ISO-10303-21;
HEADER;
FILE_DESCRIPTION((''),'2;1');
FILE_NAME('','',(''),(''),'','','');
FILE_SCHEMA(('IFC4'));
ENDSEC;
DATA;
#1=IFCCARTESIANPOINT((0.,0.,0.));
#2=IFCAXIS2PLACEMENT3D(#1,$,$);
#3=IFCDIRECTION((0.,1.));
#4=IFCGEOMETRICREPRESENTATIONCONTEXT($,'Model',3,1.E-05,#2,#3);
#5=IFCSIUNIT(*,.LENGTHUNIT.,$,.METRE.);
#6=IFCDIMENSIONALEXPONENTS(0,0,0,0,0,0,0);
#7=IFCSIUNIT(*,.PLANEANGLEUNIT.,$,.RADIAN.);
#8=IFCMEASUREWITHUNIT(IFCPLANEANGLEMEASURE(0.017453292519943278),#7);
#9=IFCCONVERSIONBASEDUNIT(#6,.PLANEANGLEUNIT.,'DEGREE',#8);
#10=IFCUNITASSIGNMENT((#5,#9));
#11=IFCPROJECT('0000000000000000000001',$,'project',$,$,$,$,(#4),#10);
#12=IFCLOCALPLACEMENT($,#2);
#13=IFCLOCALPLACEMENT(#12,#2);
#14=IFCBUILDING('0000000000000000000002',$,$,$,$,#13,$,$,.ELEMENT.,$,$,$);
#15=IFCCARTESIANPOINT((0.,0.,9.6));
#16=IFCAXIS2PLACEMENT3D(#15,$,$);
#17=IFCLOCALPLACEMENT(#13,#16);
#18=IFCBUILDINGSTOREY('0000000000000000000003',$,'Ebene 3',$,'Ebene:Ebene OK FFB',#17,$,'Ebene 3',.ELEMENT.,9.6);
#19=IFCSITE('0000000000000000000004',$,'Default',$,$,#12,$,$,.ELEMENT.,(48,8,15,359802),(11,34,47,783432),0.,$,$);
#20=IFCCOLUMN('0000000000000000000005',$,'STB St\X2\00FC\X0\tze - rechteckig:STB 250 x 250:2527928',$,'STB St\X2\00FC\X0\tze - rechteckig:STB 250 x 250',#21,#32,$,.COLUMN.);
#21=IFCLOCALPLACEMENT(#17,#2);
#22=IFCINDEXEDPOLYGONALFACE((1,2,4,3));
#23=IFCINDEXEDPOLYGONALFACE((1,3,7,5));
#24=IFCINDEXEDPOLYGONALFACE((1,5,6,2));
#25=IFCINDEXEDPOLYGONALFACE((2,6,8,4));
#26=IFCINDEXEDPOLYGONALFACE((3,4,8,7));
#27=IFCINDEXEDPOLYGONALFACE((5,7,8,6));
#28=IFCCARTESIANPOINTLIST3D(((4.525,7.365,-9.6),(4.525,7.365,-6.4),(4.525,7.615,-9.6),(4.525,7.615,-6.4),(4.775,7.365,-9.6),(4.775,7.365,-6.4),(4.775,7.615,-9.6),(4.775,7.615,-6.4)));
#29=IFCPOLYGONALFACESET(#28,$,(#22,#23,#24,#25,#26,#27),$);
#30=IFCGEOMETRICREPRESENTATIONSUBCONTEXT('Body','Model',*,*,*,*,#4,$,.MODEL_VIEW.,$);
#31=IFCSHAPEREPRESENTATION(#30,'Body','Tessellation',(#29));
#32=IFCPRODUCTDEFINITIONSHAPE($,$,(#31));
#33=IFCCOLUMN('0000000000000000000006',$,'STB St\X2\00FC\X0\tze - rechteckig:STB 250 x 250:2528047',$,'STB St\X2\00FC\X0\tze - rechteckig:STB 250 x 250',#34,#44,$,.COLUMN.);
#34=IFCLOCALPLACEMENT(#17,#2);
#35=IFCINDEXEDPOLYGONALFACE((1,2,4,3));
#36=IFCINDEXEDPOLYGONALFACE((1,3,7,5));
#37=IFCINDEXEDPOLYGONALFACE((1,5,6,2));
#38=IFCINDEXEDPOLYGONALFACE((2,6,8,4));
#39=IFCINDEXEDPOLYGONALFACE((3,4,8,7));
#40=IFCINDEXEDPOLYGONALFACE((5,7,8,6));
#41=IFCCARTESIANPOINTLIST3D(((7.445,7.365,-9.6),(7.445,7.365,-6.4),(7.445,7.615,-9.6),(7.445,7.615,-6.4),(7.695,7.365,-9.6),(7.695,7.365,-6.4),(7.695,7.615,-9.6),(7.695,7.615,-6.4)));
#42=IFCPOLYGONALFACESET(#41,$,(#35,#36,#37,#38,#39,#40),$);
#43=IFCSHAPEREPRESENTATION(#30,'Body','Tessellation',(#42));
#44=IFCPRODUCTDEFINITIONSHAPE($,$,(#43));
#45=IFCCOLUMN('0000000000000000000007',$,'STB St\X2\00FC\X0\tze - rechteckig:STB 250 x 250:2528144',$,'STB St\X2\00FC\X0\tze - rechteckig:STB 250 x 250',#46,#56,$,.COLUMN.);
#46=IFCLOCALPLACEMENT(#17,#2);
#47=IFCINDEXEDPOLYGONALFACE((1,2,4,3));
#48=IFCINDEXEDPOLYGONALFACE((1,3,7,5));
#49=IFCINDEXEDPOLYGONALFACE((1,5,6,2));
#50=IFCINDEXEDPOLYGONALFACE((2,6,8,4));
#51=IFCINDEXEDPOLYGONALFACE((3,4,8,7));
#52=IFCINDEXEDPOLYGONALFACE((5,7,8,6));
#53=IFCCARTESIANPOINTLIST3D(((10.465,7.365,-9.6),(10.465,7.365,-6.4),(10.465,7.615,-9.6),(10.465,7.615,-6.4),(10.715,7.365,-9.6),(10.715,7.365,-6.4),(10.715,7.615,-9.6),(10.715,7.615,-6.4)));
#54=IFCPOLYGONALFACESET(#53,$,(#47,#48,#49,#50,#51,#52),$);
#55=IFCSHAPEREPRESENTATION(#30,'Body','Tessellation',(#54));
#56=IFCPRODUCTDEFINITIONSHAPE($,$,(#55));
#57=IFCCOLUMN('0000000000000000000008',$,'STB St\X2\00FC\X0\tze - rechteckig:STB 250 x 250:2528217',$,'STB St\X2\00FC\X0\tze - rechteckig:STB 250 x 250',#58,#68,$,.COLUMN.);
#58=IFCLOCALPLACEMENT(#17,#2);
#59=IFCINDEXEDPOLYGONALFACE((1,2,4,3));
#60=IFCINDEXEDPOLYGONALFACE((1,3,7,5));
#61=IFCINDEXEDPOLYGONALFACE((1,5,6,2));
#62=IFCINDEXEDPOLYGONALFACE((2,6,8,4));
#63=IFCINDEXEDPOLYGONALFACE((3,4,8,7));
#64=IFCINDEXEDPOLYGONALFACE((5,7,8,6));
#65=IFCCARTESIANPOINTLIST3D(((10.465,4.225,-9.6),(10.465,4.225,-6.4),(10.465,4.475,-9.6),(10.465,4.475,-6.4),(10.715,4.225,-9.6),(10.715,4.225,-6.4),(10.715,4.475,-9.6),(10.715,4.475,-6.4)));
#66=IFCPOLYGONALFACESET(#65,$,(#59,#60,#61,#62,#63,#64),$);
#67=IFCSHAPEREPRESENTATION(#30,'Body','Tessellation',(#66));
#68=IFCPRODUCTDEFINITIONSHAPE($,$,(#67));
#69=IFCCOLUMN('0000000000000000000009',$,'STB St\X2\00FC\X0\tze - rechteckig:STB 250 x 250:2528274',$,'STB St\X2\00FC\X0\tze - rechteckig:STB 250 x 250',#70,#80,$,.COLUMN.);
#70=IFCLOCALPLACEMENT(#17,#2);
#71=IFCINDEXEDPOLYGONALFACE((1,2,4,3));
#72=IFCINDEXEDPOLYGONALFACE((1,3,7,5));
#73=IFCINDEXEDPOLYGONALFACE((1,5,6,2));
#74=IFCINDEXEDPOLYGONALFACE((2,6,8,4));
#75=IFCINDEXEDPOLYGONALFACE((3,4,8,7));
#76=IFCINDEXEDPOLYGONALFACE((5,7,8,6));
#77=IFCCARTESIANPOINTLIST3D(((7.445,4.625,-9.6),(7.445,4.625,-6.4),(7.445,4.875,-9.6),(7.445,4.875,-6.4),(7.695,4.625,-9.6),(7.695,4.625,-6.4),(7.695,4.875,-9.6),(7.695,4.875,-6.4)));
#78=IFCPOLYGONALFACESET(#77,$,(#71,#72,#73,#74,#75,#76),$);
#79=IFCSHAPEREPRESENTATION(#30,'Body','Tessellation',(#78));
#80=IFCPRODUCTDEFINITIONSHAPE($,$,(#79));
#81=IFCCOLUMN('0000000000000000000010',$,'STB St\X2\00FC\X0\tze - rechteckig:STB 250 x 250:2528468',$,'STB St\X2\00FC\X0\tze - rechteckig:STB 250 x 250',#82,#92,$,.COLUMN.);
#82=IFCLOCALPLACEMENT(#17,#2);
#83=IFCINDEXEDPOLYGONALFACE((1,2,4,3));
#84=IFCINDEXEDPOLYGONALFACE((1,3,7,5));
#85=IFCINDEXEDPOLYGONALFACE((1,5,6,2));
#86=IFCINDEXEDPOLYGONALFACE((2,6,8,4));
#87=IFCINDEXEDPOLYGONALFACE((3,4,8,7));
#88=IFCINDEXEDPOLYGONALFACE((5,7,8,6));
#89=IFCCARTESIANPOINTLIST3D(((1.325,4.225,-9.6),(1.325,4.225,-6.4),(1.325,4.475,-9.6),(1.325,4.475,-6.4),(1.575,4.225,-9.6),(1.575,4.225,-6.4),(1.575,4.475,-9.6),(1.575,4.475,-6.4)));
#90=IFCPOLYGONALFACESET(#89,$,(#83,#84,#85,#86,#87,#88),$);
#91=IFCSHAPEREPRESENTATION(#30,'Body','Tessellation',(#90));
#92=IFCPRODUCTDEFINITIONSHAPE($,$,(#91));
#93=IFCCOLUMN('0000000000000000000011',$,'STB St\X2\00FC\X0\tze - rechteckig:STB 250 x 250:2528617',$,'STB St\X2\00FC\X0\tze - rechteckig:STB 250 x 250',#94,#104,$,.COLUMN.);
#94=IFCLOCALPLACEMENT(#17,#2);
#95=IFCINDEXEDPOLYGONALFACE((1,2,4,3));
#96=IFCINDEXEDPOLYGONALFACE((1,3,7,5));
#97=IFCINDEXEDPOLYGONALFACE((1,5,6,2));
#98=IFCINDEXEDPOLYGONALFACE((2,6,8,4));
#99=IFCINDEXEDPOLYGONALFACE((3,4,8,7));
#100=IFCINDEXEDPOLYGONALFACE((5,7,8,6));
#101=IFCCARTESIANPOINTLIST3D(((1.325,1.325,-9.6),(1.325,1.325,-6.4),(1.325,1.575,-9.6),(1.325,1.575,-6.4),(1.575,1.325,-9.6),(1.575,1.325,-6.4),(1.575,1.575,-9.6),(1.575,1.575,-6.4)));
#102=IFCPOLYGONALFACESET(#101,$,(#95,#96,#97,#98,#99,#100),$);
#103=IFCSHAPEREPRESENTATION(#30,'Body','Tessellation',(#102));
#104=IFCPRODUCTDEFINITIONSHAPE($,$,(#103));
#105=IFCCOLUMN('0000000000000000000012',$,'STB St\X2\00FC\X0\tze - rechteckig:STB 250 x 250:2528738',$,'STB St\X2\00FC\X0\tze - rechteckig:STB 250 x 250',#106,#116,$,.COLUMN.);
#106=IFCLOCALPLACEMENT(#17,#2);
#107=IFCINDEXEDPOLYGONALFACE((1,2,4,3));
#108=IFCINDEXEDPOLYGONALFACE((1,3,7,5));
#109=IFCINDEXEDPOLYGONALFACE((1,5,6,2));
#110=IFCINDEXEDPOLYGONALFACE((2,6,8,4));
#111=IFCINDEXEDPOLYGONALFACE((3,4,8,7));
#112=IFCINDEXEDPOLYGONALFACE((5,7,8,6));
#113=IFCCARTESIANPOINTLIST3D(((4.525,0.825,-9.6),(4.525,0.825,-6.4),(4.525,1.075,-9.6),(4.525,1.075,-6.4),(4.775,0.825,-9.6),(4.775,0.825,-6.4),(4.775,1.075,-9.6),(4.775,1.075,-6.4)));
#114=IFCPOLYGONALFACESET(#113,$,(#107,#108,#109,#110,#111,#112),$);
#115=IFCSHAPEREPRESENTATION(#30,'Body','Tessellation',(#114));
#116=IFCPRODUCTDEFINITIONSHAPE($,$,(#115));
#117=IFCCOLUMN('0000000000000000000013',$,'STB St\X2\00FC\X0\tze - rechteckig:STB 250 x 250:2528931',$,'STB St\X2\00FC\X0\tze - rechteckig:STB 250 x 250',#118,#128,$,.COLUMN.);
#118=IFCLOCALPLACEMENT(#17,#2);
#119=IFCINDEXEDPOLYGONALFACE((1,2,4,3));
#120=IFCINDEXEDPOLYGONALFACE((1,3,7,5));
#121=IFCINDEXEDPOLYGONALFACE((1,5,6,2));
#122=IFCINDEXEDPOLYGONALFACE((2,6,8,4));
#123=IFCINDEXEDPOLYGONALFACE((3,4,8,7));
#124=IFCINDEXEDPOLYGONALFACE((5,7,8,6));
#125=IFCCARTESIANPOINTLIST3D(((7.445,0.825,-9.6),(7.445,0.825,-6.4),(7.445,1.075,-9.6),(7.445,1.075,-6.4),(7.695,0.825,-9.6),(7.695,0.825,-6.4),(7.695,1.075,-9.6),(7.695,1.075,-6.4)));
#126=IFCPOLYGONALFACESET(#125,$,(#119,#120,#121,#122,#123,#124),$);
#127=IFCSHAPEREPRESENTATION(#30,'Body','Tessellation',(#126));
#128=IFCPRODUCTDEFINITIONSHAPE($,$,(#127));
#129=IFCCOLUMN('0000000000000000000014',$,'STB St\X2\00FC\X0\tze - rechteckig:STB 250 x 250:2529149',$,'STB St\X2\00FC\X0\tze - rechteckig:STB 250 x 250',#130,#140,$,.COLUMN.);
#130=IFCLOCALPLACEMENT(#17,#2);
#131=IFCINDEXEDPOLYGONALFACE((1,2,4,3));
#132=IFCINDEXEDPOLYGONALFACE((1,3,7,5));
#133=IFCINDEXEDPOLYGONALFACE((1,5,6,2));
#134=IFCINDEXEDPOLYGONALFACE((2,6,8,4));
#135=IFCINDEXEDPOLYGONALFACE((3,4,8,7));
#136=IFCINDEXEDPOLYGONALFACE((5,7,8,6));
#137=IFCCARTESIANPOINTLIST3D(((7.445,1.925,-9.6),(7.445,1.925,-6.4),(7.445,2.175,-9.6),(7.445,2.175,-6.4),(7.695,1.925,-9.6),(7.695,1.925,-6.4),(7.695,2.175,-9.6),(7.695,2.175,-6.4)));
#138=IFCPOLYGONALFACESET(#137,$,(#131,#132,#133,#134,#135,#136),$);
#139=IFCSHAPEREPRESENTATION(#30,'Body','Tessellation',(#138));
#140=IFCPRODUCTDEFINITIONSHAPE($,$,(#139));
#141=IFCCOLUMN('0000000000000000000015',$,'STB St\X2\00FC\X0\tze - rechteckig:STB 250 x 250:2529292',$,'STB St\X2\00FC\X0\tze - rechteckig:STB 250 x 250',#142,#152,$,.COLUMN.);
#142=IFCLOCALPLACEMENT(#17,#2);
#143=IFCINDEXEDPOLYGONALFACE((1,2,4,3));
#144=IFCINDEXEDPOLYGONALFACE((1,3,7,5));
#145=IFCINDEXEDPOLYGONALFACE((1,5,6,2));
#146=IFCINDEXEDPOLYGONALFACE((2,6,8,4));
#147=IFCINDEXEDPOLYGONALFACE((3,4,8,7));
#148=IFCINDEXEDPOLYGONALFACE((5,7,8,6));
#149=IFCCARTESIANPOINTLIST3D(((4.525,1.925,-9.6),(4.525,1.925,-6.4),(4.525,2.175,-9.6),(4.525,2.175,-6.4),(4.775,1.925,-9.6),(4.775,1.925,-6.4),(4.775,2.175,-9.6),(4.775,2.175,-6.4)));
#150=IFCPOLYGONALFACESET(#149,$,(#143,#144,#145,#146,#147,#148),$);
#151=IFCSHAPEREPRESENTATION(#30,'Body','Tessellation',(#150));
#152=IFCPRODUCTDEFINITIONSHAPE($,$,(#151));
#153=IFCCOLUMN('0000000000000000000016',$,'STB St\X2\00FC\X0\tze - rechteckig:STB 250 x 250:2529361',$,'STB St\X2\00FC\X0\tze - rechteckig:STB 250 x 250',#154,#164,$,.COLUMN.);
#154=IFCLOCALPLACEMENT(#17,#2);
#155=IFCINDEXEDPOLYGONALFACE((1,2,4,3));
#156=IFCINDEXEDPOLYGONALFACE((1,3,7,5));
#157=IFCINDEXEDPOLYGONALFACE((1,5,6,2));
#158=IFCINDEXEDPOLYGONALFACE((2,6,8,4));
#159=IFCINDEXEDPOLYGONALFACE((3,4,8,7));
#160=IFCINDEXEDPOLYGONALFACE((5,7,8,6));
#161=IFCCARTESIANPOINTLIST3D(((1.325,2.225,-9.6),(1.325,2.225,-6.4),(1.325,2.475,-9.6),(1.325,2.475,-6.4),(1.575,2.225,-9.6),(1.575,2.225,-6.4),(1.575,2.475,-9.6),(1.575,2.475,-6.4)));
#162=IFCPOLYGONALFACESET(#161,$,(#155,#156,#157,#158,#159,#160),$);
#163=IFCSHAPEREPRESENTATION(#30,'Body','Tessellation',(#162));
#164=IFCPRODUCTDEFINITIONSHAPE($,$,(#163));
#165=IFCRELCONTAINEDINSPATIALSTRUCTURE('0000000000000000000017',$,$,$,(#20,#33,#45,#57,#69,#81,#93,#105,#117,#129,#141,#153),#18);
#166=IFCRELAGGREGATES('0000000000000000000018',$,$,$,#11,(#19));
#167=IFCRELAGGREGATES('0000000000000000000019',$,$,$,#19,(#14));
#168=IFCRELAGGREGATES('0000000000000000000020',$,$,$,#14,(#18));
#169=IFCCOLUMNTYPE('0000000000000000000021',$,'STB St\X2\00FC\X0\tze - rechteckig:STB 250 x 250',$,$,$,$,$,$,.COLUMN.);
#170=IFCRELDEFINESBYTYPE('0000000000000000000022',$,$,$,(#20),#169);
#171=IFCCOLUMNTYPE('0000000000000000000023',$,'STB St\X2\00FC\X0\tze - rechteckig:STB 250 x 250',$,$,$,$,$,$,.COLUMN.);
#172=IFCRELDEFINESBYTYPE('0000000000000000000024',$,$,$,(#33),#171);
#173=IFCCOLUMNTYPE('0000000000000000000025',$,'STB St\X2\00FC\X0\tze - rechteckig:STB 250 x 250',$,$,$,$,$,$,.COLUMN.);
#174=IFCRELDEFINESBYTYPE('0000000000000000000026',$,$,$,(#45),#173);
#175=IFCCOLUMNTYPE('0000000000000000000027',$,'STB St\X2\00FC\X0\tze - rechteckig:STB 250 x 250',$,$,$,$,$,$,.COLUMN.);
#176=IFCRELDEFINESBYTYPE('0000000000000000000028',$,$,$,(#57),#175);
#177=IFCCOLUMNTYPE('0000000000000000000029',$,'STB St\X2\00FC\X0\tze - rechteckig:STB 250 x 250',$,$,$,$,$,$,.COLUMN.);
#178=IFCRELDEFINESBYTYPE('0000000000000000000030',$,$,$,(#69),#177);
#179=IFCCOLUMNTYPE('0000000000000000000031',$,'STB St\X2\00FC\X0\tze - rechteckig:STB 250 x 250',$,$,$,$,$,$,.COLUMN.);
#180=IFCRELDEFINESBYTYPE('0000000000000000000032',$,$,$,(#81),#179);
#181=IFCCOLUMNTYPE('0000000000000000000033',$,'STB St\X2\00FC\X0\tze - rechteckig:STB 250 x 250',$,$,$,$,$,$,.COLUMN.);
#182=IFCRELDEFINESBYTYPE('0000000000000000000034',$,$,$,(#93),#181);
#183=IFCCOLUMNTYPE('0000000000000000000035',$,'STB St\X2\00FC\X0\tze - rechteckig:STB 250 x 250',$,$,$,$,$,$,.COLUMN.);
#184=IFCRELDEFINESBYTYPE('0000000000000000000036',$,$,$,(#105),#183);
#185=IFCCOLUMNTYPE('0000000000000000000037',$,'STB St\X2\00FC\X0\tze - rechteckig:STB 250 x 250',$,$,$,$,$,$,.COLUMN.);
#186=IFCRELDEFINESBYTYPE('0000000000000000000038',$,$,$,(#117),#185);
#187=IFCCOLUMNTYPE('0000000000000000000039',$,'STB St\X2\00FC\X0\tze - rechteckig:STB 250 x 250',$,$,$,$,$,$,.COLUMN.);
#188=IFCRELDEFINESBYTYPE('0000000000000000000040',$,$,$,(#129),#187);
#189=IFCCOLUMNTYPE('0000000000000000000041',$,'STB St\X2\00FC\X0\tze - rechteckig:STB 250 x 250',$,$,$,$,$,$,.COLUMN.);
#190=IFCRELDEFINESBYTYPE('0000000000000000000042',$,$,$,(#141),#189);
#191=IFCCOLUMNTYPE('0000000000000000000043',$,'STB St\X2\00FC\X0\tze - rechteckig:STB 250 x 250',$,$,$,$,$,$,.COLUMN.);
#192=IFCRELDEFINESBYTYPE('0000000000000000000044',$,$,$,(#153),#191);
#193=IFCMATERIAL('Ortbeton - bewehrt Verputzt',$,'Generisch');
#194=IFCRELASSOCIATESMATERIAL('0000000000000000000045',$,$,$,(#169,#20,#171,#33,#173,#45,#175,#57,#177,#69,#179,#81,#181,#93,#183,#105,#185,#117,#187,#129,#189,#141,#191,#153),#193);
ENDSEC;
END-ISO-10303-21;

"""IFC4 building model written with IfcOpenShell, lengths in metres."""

from ifc_helpers import new_model, entity, si_unit, converted_unit, direction, frame, origin, place, context, subcontext, project, spatial, indexed_curve, outline, extrude, source, transform, mapped, material, type_object, type_shapes, element, save


model = new_model("IFC4")

# Units and contexts
model_context = context("Model", 3, precision=1e-05, world=origin(), true_north=direction((0.0, 1.0)))
body_context = subcontext(model_context, "Body", "Model", "MODEL_VIEW")
ifc_project = project(units=[si_unit("LENGTHUNIT", "METRE"), converted_unit("PLANEANGLEUNIT", "DEGREE", entity("IfcPlaneAngleMeasure", 0.017453292519943278), si_unit("PLANEANGLEUNIT", "RADIAN"), dimensions=[0, 0, 0, 0, 0, 0, 0])], contexts=[model_context])

# Site, building, storey
site_placement = place(None, origin())
site = spatial("IfcSite", under=ifc_project, at=site_placement, Name="Default", CompositionType="ELEMENT", RefLatitude=(48, 8, 15, 359802), RefLongitude=(11, 34, 47, 783432), RefElevation=0.0)
building_placement = place(site_placement, origin())
building = spatial("IfcBuilding", under=site, at=building_placement, CompositionType="ELEMENT")
storey_placement = place(building_placement, frame((0.0, 0.0, 9.6)))
storey = spatial("IfcBuildingStorey", under=building, at=storey_placement, Name="Ebene 3", ObjectType="Ebene:Ebene OK FFB", LongName="Ebene 3", CompositionType="ELEMENT", Elevation=9.6)

# Columns
ifc_material_1 = material(Name="Ortbeton - bewehrt Verputzt", Category="Generisch")
column_type_1 = type_object("IfcColumnType", Name="STB Stütze - rechteckig:STB 250 x 250", PredefinedType="COLUMN", material=ifc_material_1)
shared_shape_1 = source(origin(), body_context, "Body", "SweptSolid", [
    extrude(outline(indexed_curve([(-0.125, -0.125), (0.125, -0.125), (0.125, 0.125), (-0.125, 0.125), (-0.125, -0.125)], self_intersect=False)), frame((4.65, 7.49, 0.0), z_axis=(0.0, 0.0, 1.0), x_axis=(-1.0, 0.0, 0.0)), (0.0, 0.0, 1.0), 3.2),
])
type_shapes(column_type_1, [shared_shape_1])
column_1_placement = place(storey_placement, frame((0.0, 0.0, -9.6)))
element("IfcColumn", 1, at=column_1_placement, inside=storey, type_object=column_type_1, material=ifc_material_1, Name="STB Stütze - rechteckig:STB 250 x 250:2527928", ObjectType="STB Stütze - rechteckig:STB 250 x 250", PredefinedType="COLUMN", context=body_context, shape_type="MappedRepresentation", body=[
    mapped(shared_shape_1, transform((0.0, 0.0, 0.0), scale=1.0)),
])
column_type_2 = type_object("IfcColumnType", Name="STB Stütze - rechteckig:STB 250 x 250", PredefinedType="COLUMN", material=ifc_material_1)
shared_shape_2 = source(origin(), body_context, "Body", "SweptSolid", [
    extrude(outline(indexed_curve([(-0.125, -0.125), (0.125, -0.125), (0.125, 0.125), (-0.125, 0.125), (-0.125, -0.125)], self_intersect=False)), frame((7.57, 7.49, 0.0), z_axis=(0.0, 0.0, 1.0), x_axis=(-1.0, 0.0, 0.0)), (0.0, 0.0, 1.0), 3.2),
])
type_shapes(column_type_2, [shared_shape_2])
column_2_placement = place(storey_placement, frame((0.0, 0.0, -9.6)))
element("IfcColumn", 2, at=column_2_placement, inside=storey, type_object=column_type_2, material=ifc_material_1, Name="STB Stütze - rechteckig:STB 250 x 250:2528047", ObjectType="STB Stütze - rechteckig:STB 250 x 250", PredefinedType="COLUMN", context=body_context, shape_type="MappedRepresentation", body=[
    mapped(shared_shape_2, transform((0.0, 0.0, 0.0), scale=1.0)),
])
column_type_3 = type_object("IfcColumnType", Name="STB Stütze - rechteckig:STB 250 x 250", PredefinedType="COLUMN", material=ifc_material_1)
shared_shape_3 = source(origin(), body_context, "Body", "SweptSolid", [
    extrude(outline(indexed_curve([(-0.125, -0.125), (0.125, -0.125), (0.125, 0.125), (-0.125, 0.125), (-0.125, -0.125)], self_intersect=False)), frame((10.59, 7.49, 0.0), z_axis=(0.0, 0.0, 1.0), x_axis=(-1.0, 0.0, 0.0)), (0.0, 0.0, 1.0), 3.2),
])
type_shapes(column_type_3, [shared_shape_3])
column_3_placement = place(storey_placement, frame((0.0, 0.0, -9.6)))
element("IfcColumn", 3, at=column_3_placement, inside=storey, type_object=column_type_3, material=ifc_material_1, Name="STB Stütze - rechteckig:STB 250 x 250:2528144", ObjectType="STB Stütze - rechteckig:STB 250 x 250", PredefinedType="COLUMN", context=body_context, shape_type="MappedRepresentation", body=[
    mapped(shared_shape_3, transform((0.0, 0.0, 0.0), scale=1.0)),
])
column_type_4 = type_object("IfcColumnType", Name="STB Stütze - rechteckig:STB 250 x 250", PredefinedType="COLUMN", material=ifc_material_1)
shared_shape_4 = source(origin(), body_context, "Body", "SweptSolid", [
    extrude(outline(indexed_curve([(-0.125, -0.125), (0.125, -0.125), (0.125, 0.125), (-0.125, 0.125), (-0.125, -0.125)], self_intersect=False)), frame((10.59, 4.35, 0.0), z_axis=(0.0, 0.0, 1.0), x_axis=(-1.0, 0.0, 0.0)), (0.0, 0.0, 1.0), 3.2),
])
type_shapes(column_type_4, [shared_shape_4])
column_4_placement = place(storey_placement, frame((0.0, 0.0, -9.6)))
element("IfcColumn", 4, at=column_4_placement, inside=storey, type_object=column_type_4, material=ifc_material_1, Name="STB Stütze - rechteckig:STB 250 x 250:2528217", ObjectType="STB Stütze - rechteckig:STB 250 x 250", PredefinedType="COLUMN", context=body_context, shape_type="MappedRepresentation", body=[
    mapped(shared_shape_4, transform((0.0, 0.0, 0.0), scale=1.0)),
])
column_type_5 = type_object("IfcColumnType", Name="STB Stütze - rechteckig:STB 250 x 250", PredefinedType="COLUMN", material=ifc_material_1)
shared_shape_5 = source(origin(), body_context, "Body", "SweptSolid", [
    extrude(outline(indexed_curve([(-0.125, -0.125), (0.125, -0.125), (0.125, 0.125), (-0.125, 0.125), (-0.125, -0.125)], self_intersect=False)), frame((7.57, 4.75, 0.0), z_axis=(0.0, 0.0, 1.0), x_axis=(-1.0, 0.0, 0.0)), (0.0, 0.0, 1.0), 3.2),
])
type_shapes(column_type_5, [shared_shape_5])
column_5_placement = place(storey_placement, frame((0.0, 0.0, -9.6)))
element("IfcColumn", 5, at=column_5_placement, inside=storey, type_object=column_type_5, material=ifc_material_1, Name="STB Stütze - rechteckig:STB 250 x 250:2528274", ObjectType="STB Stütze - rechteckig:STB 250 x 250", PredefinedType="COLUMN", context=body_context, shape_type="MappedRepresentation", body=[
    mapped(shared_shape_5, transform((0.0, 0.0, 0.0), scale=1.0)),
])
column_type_6 = type_object("IfcColumnType", Name="STB Stütze - rechteckig:STB 250 x 250", PredefinedType="COLUMN", material=ifc_material_1)
shared_shape_6 = source(origin(), body_context, "Body", "SweptSolid", [
    extrude(outline(indexed_curve([(-0.125, -0.125), (0.125, -0.125), (0.125, 0.125), (-0.125, 0.125), (-0.125, -0.125)], self_intersect=False)), frame((1.45, 4.35, 0.0), z_axis=(0.0, 0.0, 1.0), x_axis=(-1.0, 0.0, 0.0)), (0.0, 0.0, 1.0), 3.2),
])
type_shapes(column_type_6, [shared_shape_6])
column_6_placement = place(storey_placement, frame((0.0, 0.0, -9.6)))
element("IfcColumn", 6, at=column_6_placement, inside=storey, type_object=column_type_6, material=ifc_material_1, Name="STB Stütze - rechteckig:STB 250 x 250:2528468", ObjectType="STB Stütze - rechteckig:STB 250 x 250", PredefinedType="COLUMN", context=body_context, shape_type="MappedRepresentation", body=[
    mapped(shared_shape_6, transform((0.0, 0.0, 0.0), scale=1.0)),
])
column_type_7 = type_object("IfcColumnType", Name="STB Stütze - rechteckig:STB 250 x 250", PredefinedType="COLUMN", material=ifc_material_1)
shared_shape_7 = source(origin(), body_context, "Body", "SweptSolid", [
    extrude(outline(indexed_curve([(-0.125, -0.125), (0.125, -0.125), (0.125, 0.125), (-0.125, 0.125), (-0.125, -0.125)], self_intersect=False)), frame((1.45, 1.45, 0.0), z_axis=(0.0, 0.0, 1.0), x_axis=(-1.0, 0.0, 0.0)), (0.0, 0.0, 1.0), 3.2),
])
type_shapes(column_type_7, [shared_shape_7])
column_7_placement = place(storey_placement, frame((0.0, 0.0, -9.6)))
element("IfcColumn", 7, at=column_7_placement, inside=storey, type_object=column_type_7, material=ifc_material_1, Name="STB Stütze - rechteckig:STB 250 x 250:2528617", ObjectType="STB Stütze - rechteckig:STB 250 x 250", PredefinedType="COLUMN", context=body_context, shape_type="MappedRepresentation", body=[
    mapped(shared_shape_7, transform((0.0, 0.0, 0.0), scale=1.0)),
])
column_type_8 = type_object("IfcColumnType", Name="STB Stütze - rechteckig:STB 250 x 250", PredefinedType="COLUMN", material=ifc_material_1)
shared_shape_8 = source(origin(), body_context, "Body", "SweptSolid", [
    extrude(outline(indexed_curve([(-0.125, -0.125), (0.125, -0.125), (0.125, 0.125), (-0.125, 0.125), (-0.125, -0.125)], self_intersect=False)), frame((4.65, 0.95, 0.0), z_axis=(0.0, 0.0, 1.0), x_axis=(-1.0, 0.0, 0.0)), (0.0, 0.0, 1.0), 3.2),
])
type_shapes(column_type_8, [shared_shape_8])
column_8_placement = place(storey_placement, frame((0.0, 0.0, -9.6)))
element("IfcColumn", 8, at=column_8_placement, inside=storey, type_object=column_type_8, material=ifc_material_1, Name="STB Stütze - rechteckig:STB 250 x 250:2528738", ObjectType="STB Stütze - rechteckig:STB 250 x 250", PredefinedType="COLUMN", context=body_context, shape_type="MappedRepresentation", body=[
    mapped(shared_shape_8, transform((0.0, 0.0, 0.0), scale=1.0)),
])
column_type_9 = type_object("IfcColumnType", Name="STB Stütze - rechteckig:STB 250 x 250", PredefinedType="COLUMN", material=ifc_material_1)
shared_shape_9 = source(origin(), body_context, "Body", "SweptSolid", [
    extrude(outline(indexed_curve([(-0.125, -0.125), (0.125, -0.125), (0.125, 0.125), (-0.125, 0.125), (-0.125, -0.125)], self_intersect=False)), frame((7.57, 0.95, 0.0), z_axis=(0.0, 0.0, 1.0), x_axis=(-1.0, 0.0, 0.0)), (0.0, 0.0, 1.0), 3.2),
])
type_shapes(column_type_9, [shared_shape_9])
column_9_placement = place(storey_placement, frame((0.0, 0.0, -9.6)))
element("IfcColumn", 9, at=column_9_placement, inside=storey, type_object=column_type_9, material=ifc_material_1, Name="STB Stütze - rechteckig:STB 250 x 250:2528931", ObjectType="STB Stütze - rechteckig:STB 250 x 250", PredefinedType="COLUMN", context=body_context, shape_type="MappedRepresentation", body=[
    mapped(shared_shape_9, transform((0.0, 0.0, 0.0), scale=1.0)),
])
column_type_10 = type_object("IfcColumnType", Name="STB Stütze - rechteckig:STB 250 x 250", PredefinedType="COLUMN", material=ifc_material_1)
shared_shape_10 = source(origin(), body_context, "Body", "SweptSolid", [
    extrude(outline(indexed_curve([(-0.125, -0.125), (0.125, -0.125), (0.125, 0.125), (-0.125, 0.125), (-0.125, -0.125)], self_intersect=False)), frame((7.57, 2.05, 0.0), z_axis=(0.0, 0.0, 1.0), x_axis=(-1.0, 0.0, 0.0)), (0.0, 0.0, 1.0), 3.2),
])
type_shapes(column_type_10, [shared_shape_10])
column_10_placement = place(storey_placement, frame((0.0, 0.0, -9.6)))
element("IfcColumn", 10, at=column_10_placement, inside=storey, type_object=column_type_10, material=ifc_material_1, Name="STB Stütze - rechteckig:STB 250 x 250:2529149", ObjectType="STB Stütze - rechteckig:STB 250 x 250", PredefinedType="COLUMN", context=body_context, shape_type="MappedRepresentation", body=[
    mapped(shared_shape_10, transform((0.0, 0.0, 0.0), scale=1.0)),
])
column_type_11 = type_object("IfcColumnType", Name="STB Stütze - rechteckig:STB 250 x 250", PredefinedType="COLUMN", material=ifc_material_1)
shared_shape_11 = source(origin(), body_context, "Body", "SweptSolid", [
    extrude(outline(indexed_curve([(-0.125, -0.125), (0.125, -0.125), (0.125, 0.125), (-0.125, 0.125), (-0.125, -0.125)], self_intersect=False)), frame((4.65, 2.05, 0.0), z_axis=(0.0, 0.0, 1.0), x_axis=(-1.0, 0.0, 0.0)), (0.0, 0.0, 1.0), 3.2),
])
type_shapes(column_type_11, [shared_shape_11])
column_11_placement = place(storey_placement, frame((0.0, 0.0, -9.6)))
element("IfcColumn", 11, at=column_11_placement, inside=storey, type_object=column_type_11, material=ifc_material_1, Name="STB Stütze - rechteckig:STB 250 x 250:2529292", ObjectType="STB Stütze - rechteckig:STB 250 x 250", PredefinedType="COLUMN", context=body_context, shape_type="MappedRepresentation", body=[
    mapped(shared_shape_11, transform((0.0, 0.0, 0.0), scale=1.0)),
])
column_type_12 = type_object("IfcColumnType", Name="STB Stütze - rechteckig:STB 250 x 250", PredefinedType="COLUMN", material=ifc_material_1)
shared_shape_12 = source(origin(), body_context, "Body", "SweptSolid", [
    extrude(outline(indexed_curve([(-0.125, -0.125), (0.125, -0.125), (0.125, 0.125), (-0.125, 0.125), (-0.125, -0.125)], self_intersect=False)), frame((1.45, 2.35, 0.0), z_axis=(0.0, 0.0, 1.0), x_axis=(-1.0, 0.0, 0.0)), (0.0, 0.0, 1.0), 3.2),
])
type_shapes(column_type_12, [shared_shape_12])
column_12_placement = place(storey_placement, frame((0.0, 0.0, -9.6)))
element("IfcColumn", 12, at=column_12_placement, inside=storey, type_object=column_type_12, material=ifc_material_1, Name="STB Stütze - rechteckig:STB 250 x 250:2529361", ObjectType="STB Stütze - rechteckig:STB 250 x 250", PredefinedType="COLUMN", context=body_context, shape_type="MappedRepresentation", body=[
    mapped(shared_shape_12, transform((0.0, 0.0, 0.0), scale=1.0)),
])

save(model, "model.ifc")
